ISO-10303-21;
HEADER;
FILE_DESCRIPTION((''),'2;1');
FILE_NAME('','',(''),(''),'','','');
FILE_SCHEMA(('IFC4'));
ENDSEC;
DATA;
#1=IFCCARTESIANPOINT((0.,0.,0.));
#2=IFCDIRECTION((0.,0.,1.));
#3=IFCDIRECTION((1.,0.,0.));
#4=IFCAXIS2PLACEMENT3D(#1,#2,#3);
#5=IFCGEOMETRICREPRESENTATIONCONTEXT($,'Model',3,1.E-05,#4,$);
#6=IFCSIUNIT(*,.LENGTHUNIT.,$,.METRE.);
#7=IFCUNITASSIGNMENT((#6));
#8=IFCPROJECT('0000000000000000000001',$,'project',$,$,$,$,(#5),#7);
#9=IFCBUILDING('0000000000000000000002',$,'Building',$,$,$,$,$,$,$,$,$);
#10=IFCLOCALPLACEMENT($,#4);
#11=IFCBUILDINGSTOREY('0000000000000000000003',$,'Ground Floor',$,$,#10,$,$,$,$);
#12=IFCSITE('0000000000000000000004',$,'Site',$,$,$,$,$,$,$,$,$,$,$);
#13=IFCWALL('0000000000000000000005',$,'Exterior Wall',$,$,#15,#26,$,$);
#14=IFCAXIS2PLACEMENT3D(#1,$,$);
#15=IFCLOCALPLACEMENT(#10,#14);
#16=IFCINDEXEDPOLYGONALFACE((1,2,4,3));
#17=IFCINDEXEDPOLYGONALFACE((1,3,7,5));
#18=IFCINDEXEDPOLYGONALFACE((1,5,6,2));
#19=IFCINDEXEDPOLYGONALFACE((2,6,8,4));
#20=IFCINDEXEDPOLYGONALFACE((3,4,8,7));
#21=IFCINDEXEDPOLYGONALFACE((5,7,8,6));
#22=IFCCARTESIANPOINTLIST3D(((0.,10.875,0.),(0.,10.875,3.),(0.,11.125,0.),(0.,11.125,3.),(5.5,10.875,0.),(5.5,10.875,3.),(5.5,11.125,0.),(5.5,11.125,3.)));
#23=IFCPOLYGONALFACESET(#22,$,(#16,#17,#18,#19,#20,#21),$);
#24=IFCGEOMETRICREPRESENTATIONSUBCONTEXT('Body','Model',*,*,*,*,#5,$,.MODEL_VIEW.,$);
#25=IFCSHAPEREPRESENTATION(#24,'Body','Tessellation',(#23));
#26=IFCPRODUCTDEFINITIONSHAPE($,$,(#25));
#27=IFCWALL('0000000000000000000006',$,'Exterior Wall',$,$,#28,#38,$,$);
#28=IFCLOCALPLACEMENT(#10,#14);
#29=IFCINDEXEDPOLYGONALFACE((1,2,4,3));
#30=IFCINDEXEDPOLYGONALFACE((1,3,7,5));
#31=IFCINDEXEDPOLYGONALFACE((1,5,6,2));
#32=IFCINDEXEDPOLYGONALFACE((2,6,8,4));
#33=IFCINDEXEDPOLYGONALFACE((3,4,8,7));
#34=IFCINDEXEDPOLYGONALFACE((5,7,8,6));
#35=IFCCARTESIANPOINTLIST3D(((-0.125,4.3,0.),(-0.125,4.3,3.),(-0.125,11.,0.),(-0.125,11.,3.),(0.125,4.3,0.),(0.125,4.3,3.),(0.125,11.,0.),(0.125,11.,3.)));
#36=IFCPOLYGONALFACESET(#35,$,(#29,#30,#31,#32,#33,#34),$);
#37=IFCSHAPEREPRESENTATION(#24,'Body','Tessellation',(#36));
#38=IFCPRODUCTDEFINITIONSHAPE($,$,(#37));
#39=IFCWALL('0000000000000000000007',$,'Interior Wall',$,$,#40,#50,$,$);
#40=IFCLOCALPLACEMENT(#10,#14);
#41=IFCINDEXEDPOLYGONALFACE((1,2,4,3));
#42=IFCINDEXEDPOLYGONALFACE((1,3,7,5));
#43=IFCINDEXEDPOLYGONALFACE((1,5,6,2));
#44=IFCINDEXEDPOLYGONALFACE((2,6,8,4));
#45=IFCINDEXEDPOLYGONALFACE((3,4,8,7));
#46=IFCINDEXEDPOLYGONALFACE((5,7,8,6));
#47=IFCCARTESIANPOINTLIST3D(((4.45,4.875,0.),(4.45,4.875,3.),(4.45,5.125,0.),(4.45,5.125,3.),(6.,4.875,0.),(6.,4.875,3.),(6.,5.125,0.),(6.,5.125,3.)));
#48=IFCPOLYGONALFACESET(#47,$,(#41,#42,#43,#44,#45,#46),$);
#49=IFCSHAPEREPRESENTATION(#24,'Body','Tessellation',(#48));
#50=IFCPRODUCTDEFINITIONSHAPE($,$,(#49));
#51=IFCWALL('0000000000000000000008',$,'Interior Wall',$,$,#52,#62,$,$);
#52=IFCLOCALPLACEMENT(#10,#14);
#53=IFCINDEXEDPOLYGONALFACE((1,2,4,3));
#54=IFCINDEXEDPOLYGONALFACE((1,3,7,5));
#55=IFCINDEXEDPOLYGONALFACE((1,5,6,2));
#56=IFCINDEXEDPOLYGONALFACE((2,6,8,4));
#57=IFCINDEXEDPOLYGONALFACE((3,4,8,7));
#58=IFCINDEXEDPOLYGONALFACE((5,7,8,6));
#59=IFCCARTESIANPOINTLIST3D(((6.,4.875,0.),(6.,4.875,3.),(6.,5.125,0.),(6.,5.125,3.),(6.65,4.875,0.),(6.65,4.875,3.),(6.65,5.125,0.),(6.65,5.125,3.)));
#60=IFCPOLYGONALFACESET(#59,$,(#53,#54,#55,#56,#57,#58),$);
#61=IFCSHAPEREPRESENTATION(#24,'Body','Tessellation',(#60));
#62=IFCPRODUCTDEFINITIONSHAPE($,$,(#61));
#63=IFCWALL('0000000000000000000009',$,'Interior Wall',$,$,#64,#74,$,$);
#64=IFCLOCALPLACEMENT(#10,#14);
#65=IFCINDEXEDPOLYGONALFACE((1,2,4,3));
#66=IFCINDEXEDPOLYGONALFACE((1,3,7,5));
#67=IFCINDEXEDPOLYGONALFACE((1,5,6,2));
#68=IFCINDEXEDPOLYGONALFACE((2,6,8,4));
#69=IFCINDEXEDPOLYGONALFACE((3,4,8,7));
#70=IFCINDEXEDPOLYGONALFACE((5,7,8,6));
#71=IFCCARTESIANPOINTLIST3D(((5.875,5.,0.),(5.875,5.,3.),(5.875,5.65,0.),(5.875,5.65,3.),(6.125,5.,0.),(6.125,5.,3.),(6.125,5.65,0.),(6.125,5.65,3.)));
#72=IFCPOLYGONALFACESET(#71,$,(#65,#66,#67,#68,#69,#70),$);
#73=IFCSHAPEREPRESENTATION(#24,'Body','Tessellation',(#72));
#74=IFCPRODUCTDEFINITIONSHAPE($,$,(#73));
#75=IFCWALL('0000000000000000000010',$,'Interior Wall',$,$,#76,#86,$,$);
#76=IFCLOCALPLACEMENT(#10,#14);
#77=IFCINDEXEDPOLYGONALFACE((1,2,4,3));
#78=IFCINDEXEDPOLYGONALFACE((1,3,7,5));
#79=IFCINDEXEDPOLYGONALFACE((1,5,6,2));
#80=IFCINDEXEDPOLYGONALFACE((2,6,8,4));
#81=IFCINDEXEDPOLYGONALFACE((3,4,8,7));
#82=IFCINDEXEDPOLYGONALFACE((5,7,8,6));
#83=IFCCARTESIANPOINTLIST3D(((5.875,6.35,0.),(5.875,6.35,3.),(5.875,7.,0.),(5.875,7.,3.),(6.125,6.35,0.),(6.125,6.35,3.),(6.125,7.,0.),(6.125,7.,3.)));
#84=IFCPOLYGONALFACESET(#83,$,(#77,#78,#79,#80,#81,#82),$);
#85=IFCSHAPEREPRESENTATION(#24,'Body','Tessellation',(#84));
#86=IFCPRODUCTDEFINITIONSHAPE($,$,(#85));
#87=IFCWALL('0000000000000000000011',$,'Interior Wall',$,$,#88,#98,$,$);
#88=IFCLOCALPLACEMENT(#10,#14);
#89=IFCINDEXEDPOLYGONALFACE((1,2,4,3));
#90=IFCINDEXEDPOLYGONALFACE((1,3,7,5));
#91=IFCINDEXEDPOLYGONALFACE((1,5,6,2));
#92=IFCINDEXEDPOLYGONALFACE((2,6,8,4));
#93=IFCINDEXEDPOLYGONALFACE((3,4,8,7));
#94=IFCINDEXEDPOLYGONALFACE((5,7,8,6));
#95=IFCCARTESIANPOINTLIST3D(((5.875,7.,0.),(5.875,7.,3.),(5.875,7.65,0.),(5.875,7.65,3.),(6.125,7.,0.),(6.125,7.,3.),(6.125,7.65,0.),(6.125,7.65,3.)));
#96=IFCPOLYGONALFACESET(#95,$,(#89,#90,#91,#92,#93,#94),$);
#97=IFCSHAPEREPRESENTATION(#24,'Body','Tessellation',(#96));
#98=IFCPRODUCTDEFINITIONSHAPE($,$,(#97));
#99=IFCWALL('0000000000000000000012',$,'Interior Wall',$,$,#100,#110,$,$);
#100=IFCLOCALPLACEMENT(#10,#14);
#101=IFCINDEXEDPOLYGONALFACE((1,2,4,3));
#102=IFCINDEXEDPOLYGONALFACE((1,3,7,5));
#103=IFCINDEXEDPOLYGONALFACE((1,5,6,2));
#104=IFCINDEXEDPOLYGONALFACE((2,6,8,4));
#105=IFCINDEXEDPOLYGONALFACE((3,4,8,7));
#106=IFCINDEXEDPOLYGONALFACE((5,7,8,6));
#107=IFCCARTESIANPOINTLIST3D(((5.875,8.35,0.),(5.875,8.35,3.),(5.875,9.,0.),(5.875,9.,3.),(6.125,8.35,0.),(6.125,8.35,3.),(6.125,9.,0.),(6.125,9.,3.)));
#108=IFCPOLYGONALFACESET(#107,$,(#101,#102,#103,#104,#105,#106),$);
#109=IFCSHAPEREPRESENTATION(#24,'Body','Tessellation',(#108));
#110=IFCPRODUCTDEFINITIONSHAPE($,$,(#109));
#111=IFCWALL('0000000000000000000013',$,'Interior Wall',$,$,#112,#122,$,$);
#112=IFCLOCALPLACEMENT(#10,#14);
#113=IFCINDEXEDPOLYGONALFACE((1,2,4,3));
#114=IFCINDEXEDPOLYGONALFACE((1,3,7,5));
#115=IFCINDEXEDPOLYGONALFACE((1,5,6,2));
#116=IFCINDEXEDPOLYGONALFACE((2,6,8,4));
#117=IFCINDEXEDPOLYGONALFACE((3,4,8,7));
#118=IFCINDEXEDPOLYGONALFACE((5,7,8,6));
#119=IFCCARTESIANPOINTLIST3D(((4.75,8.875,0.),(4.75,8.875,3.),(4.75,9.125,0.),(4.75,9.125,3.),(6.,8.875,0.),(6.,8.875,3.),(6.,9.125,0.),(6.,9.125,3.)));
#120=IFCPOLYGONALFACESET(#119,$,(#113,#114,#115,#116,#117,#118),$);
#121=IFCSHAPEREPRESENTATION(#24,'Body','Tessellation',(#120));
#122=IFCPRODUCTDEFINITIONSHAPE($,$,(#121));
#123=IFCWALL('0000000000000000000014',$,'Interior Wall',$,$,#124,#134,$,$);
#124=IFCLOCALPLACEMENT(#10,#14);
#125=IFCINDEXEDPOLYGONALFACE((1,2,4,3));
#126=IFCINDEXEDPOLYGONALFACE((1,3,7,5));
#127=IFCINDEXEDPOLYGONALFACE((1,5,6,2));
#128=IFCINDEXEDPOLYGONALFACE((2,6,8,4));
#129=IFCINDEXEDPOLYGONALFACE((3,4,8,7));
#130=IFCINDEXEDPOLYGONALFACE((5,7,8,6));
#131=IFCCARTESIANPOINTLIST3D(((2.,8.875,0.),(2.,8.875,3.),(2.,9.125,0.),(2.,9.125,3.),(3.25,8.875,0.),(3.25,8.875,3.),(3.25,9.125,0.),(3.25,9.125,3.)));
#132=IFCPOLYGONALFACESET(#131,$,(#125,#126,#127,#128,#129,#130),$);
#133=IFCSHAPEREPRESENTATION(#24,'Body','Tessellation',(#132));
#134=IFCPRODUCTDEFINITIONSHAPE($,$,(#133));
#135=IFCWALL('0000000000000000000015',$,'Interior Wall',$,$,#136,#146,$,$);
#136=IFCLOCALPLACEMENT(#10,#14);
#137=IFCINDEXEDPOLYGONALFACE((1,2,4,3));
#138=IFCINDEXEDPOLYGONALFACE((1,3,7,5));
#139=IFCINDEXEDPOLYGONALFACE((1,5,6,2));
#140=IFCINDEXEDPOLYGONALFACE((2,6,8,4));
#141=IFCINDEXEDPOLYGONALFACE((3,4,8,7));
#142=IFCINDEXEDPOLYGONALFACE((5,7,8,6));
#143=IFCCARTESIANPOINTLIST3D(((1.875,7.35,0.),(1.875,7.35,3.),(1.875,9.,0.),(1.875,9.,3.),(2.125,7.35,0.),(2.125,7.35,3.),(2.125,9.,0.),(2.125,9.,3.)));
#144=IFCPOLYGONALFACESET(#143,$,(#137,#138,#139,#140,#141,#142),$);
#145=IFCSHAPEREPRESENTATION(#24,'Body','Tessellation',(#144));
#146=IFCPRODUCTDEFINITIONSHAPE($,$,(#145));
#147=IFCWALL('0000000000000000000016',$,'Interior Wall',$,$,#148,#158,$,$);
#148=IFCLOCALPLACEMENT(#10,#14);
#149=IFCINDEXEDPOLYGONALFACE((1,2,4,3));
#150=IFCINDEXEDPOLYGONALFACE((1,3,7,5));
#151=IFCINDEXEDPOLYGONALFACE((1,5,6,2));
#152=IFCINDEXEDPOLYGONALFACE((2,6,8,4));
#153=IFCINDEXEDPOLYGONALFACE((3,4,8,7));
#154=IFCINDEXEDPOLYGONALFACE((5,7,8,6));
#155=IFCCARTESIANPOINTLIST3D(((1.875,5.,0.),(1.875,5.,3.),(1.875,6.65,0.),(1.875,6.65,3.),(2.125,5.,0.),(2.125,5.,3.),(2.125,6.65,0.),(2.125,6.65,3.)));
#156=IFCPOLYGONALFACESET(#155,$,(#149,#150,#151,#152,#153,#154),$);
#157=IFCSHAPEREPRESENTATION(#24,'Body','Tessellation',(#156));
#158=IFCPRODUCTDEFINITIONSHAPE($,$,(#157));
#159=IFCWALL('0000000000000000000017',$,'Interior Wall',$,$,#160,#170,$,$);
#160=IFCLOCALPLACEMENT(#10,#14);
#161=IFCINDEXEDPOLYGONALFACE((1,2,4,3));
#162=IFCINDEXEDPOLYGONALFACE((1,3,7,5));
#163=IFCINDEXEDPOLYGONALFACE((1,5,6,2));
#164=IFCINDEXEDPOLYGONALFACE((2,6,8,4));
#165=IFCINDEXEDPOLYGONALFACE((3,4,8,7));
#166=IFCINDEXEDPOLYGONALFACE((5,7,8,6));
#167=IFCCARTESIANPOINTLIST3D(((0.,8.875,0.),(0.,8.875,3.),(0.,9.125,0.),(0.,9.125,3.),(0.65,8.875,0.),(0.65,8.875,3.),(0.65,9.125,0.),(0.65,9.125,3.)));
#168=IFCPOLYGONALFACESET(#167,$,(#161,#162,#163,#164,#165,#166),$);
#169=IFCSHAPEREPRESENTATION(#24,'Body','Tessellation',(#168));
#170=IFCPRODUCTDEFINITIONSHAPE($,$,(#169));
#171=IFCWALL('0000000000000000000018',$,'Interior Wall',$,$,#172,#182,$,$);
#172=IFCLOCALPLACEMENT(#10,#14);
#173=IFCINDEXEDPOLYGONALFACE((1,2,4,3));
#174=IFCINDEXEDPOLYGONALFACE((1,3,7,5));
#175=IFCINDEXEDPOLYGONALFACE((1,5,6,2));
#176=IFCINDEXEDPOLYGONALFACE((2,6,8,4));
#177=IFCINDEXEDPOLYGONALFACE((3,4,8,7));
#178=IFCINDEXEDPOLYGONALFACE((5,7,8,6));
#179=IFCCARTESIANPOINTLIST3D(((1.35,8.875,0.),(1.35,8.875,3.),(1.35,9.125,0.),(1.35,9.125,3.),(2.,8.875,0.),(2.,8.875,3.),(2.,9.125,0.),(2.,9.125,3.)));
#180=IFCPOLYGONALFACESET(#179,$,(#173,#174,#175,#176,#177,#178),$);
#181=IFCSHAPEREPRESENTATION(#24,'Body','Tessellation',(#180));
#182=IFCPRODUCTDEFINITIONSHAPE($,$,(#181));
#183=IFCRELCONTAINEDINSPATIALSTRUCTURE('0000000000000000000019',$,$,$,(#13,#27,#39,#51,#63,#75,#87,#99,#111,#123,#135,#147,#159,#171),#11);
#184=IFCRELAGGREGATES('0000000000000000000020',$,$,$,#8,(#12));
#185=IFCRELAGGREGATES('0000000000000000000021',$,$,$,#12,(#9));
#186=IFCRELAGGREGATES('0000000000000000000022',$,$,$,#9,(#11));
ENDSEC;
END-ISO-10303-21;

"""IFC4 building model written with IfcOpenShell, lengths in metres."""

from ifc_helpers import new_model, si_unit, frame, origin_with_axes, place, context, subcontext, project, spatial, indexed_curve, outline, extrude, element, save


model = new_model("IFC4")

# Units and contexts
model_context = context("Model", 3, precision=1e-05, world=origin_with_axes())
body_context = subcontext(model_context, "Body", "Model", "MODEL_VIEW")
ifc_project = project(units=[si_unit("LENGTHUNIT", "METRE")], contexts=[model_context])

# Site, building, storey
site = spatial("IfcSite", under=ifc_project, Name="Site")
building = spatial("IfcBuilding", under=site, Name="Building")
storey_placement = place(None, origin_with_axes())
storey = spatial("IfcBuildingStorey", under=building, at=storey_placement, Name="Ground Floor")

# Walls
wall_1_placement = place(storey_placement, frame((5.5, 11.0, 0.0), z_axis=(0.0, 0.0, 1.0), x_axis=(-1.0, 0.0, 0.0)))
element("IfcWall", 1, at=wall_1_placement, inside=storey, Name="Exterior Wall", context=body_context, shape_type="SweptSolid", body=[
    extrude(outline(indexed_curve([(0.0, 0.0), (0.0, 0.25), (5.5, 0.25), (5.5, 0.0), (0.0, 0.0)], self_intersect=False)), frame((0.0, -0.125, 0.0), z_axis=(0.0, 0.0, 1.0), x_axis=(1.0, 0.0, 0.0)), (0.0, 0.0, 1.0), 3.0),
])
wall_2_placement = place(storey_placement, frame((0.0, 11.0, 0.0), z_axis=(0.0, 0.0, 1.0), x_axis=(0.0, -1.0, 0.0)))
element("IfcWall", 2, at=wall_2_placement, inside=storey, Name="Exterior Wall", context=body_context, shape_type="SweptSolid", body=[
    extrude(outline(indexed_curve([(0.0, 0.0), (0.0, 0.25), (6.7, 0.25), (6.7, 0.0), (0.0, 0.0)], self_intersect=False)), frame((0.0, -0.125, 0.0), z_axis=(0.0, 0.0, 1.0), x_axis=(1.0, 0.0, 0.0)), (0.0, 0.0, 1.0), 3.0),
])
wall_3_placement = place(storey_placement, frame((6.0, 5.0, 0.0), z_axis=(0.0, 0.0, 1.0), x_axis=(-1.0, 0.0, 0.0)))
element("IfcWall", 3, at=wall_3_placement, inside=storey, Name="Interior Wall", context=body_context, shape_type="SweptSolid", body=[
    extrude(outline(indexed_curve([(0.0, 0.0), (0.0, 0.25), (1.55, 0.25), (1.55, 0.0), (0.0, 0.0)], self_intersect=False)), frame((0.0, -0.125, 0.0), z_axis=(0.0, 0.0, 1.0), x_axis=(1.0, 0.0, 0.0)), (0.0, 0.0, 1.0), 3.0),
])
for number, where, z_axis, x_axis, name in (
    (4, (6.65, 5.0, 0.0), (0.0, 0.0, 1.0), (-1.0, 0.0, 0.0), "Interior Wall"),
    (5, (6.0, 5.0, 0.0), (0.0, 0.0, 1.0), (0.0, 1.0, 0.0), "Interior Wall"),
    (6, (6.0, 6.35, 0.0), (0.0, 0.0, 1.0), (0.0, 1.0, 0.0), "Interior Wall"),
    (7, (6.0, 7.0, 0.0), (0.0, 0.0, 1.0), (0.0, 1.0, 0.0), "Interior Wall"),
    (8, (6.0, 8.35, 0.0), (0.0, 0.0, 1.0), (0.0, 1.0, 0.0), "Interior Wall"),
):
    element("IfcWall", number, at=place(storey_placement, frame(where, z_axis=z_axis, x_axis=x_axis)), inside=storey, Name=name, context=body_context, shape_type="SweptSolid", body=[
        extrude(outline(indexed_curve([(0.0, 0.0), (0.0, 0.25), (0.65, 0.25), (0.65, 0.0), (0.0, 0.0)], self_intersect=False)), frame((0.0, -0.125, 0.0), z_axis=(0.0, 0.0, 1.0), x_axis=(1.0, 0.0, 0.0)), (0.0, 0.0, 1.0), 3.0),
    ])
for number, where, z_axis, x_axis, name in (
    (9, (6.0, 9.0, 0.0), (0.0, 0.0, 1.0), (-1.0, 0.0, 0.0), "Interior Wall"),
    (10, (3.25, 9.0, 0.0), (0.0, 0.0, 1.0), (-1.0, 0.0, 0.0), "Interior Wall"),
):
    element("IfcWall", number, at=place(storey_placement, frame(where, z_axis=z_axis, x_axis=x_axis)), inside=storey, Name=name, context=body_context, shape_type="SweptSolid", body=[
        extrude(outline(indexed_curve([(0.0, 0.0), (0.0, 0.25), (1.25, 0.25), (1.25, 0.0), (0.0, 0.0)], self_intersect=False)), frame((0.0, -0.125, 0.0), z_axis=(0.0, 0.0, 1.0), x_axis=(1.0, 0.0, 0.0)), (0.0, 0.0, 1.0), 3.0),
    ])
for number, where, z_axis, x_axis, name in (
    (11, (2.0, 9.0, 0.0), (0.0, 0.0, 1.0), (0.0, -1.0, 0.0), "Interior Wall"),
    (12, (2.0, 6.65, 0.0), (0.0, 0.0, 1.0), (0.0, -1.0, 0.0), "Interior Wall"),
):
    element("IfcWall", number, at=place(storey_placement, frame(where, z_axis=z_axis, x_axis=x_axis)), inside=storey, Name=name, context=body_context, shape_type="SweptSolid", body=[
        extrude(outline(indexed_curve([(0.0, 0.0), (0.0, 0.25), (1.65, 0.25), (1.65, 0.0), (0.0, 0.0)], self_intersect=False)), frame((0.0, -0.125, 0.0), z_axis=(0.0, 0.0, 1.0), x_axis=(1.0, 0.0, 0.0)), (0.0, 0.0, 1.0), 3.0),
    ])
wall_4_placement = place(storey_placement, frame((0.0, 9.0, 0.0), z_axis=(0.0, 0.0, 1.0), x_axis=(1.0, 0.0, 0.0)))
element("IfcWall", 13, at=wall_4_placement, inside=storey, Name="Interior Wall", context=body_context, shape_type="SweptSolid", body=[
    extrude(outline(indexed_curve([(0.0, 0.0), (0.0, 0.25), (0.65, 0.25), (0.65, 0.0), (0.0, 0.0)], self_intersect=False)), frame((0.0, -0.125, 0.0), z_axis=(0.0, 0.0, 1.0), x_axis=(1.0, 0.0, 0.0)), (0.0, 0.0, 1.0), 3.0),
])
wall_5_placement = place(storey_placement, frame((1.35, 9.0, 0.0), z_axis=(0.0, 0.0, 1.0), x_axis=(1.0, 0.0, 0.0)))
element("IfcWall", 14, at=wall_5_placement, inside=storey, Name="Interior Wall", context=body_context, shape_type="SweptSolid", body=[
    extrude(outline(indexed_curve([(0.0, 0.0), (0.0, 0.25), (0.65, 0.25), (0.65, 0.0), (0.0, 0.0)], self_intersect=False)), frame((0.0, -0.125, 0.0), z_axis=(0.0, 0.0, 1.0), x_axis=(1.0, 0.0, 0.0)), (0.0, 0.0, 1.0), 3.0),
])

save(model, "model.ifc")
